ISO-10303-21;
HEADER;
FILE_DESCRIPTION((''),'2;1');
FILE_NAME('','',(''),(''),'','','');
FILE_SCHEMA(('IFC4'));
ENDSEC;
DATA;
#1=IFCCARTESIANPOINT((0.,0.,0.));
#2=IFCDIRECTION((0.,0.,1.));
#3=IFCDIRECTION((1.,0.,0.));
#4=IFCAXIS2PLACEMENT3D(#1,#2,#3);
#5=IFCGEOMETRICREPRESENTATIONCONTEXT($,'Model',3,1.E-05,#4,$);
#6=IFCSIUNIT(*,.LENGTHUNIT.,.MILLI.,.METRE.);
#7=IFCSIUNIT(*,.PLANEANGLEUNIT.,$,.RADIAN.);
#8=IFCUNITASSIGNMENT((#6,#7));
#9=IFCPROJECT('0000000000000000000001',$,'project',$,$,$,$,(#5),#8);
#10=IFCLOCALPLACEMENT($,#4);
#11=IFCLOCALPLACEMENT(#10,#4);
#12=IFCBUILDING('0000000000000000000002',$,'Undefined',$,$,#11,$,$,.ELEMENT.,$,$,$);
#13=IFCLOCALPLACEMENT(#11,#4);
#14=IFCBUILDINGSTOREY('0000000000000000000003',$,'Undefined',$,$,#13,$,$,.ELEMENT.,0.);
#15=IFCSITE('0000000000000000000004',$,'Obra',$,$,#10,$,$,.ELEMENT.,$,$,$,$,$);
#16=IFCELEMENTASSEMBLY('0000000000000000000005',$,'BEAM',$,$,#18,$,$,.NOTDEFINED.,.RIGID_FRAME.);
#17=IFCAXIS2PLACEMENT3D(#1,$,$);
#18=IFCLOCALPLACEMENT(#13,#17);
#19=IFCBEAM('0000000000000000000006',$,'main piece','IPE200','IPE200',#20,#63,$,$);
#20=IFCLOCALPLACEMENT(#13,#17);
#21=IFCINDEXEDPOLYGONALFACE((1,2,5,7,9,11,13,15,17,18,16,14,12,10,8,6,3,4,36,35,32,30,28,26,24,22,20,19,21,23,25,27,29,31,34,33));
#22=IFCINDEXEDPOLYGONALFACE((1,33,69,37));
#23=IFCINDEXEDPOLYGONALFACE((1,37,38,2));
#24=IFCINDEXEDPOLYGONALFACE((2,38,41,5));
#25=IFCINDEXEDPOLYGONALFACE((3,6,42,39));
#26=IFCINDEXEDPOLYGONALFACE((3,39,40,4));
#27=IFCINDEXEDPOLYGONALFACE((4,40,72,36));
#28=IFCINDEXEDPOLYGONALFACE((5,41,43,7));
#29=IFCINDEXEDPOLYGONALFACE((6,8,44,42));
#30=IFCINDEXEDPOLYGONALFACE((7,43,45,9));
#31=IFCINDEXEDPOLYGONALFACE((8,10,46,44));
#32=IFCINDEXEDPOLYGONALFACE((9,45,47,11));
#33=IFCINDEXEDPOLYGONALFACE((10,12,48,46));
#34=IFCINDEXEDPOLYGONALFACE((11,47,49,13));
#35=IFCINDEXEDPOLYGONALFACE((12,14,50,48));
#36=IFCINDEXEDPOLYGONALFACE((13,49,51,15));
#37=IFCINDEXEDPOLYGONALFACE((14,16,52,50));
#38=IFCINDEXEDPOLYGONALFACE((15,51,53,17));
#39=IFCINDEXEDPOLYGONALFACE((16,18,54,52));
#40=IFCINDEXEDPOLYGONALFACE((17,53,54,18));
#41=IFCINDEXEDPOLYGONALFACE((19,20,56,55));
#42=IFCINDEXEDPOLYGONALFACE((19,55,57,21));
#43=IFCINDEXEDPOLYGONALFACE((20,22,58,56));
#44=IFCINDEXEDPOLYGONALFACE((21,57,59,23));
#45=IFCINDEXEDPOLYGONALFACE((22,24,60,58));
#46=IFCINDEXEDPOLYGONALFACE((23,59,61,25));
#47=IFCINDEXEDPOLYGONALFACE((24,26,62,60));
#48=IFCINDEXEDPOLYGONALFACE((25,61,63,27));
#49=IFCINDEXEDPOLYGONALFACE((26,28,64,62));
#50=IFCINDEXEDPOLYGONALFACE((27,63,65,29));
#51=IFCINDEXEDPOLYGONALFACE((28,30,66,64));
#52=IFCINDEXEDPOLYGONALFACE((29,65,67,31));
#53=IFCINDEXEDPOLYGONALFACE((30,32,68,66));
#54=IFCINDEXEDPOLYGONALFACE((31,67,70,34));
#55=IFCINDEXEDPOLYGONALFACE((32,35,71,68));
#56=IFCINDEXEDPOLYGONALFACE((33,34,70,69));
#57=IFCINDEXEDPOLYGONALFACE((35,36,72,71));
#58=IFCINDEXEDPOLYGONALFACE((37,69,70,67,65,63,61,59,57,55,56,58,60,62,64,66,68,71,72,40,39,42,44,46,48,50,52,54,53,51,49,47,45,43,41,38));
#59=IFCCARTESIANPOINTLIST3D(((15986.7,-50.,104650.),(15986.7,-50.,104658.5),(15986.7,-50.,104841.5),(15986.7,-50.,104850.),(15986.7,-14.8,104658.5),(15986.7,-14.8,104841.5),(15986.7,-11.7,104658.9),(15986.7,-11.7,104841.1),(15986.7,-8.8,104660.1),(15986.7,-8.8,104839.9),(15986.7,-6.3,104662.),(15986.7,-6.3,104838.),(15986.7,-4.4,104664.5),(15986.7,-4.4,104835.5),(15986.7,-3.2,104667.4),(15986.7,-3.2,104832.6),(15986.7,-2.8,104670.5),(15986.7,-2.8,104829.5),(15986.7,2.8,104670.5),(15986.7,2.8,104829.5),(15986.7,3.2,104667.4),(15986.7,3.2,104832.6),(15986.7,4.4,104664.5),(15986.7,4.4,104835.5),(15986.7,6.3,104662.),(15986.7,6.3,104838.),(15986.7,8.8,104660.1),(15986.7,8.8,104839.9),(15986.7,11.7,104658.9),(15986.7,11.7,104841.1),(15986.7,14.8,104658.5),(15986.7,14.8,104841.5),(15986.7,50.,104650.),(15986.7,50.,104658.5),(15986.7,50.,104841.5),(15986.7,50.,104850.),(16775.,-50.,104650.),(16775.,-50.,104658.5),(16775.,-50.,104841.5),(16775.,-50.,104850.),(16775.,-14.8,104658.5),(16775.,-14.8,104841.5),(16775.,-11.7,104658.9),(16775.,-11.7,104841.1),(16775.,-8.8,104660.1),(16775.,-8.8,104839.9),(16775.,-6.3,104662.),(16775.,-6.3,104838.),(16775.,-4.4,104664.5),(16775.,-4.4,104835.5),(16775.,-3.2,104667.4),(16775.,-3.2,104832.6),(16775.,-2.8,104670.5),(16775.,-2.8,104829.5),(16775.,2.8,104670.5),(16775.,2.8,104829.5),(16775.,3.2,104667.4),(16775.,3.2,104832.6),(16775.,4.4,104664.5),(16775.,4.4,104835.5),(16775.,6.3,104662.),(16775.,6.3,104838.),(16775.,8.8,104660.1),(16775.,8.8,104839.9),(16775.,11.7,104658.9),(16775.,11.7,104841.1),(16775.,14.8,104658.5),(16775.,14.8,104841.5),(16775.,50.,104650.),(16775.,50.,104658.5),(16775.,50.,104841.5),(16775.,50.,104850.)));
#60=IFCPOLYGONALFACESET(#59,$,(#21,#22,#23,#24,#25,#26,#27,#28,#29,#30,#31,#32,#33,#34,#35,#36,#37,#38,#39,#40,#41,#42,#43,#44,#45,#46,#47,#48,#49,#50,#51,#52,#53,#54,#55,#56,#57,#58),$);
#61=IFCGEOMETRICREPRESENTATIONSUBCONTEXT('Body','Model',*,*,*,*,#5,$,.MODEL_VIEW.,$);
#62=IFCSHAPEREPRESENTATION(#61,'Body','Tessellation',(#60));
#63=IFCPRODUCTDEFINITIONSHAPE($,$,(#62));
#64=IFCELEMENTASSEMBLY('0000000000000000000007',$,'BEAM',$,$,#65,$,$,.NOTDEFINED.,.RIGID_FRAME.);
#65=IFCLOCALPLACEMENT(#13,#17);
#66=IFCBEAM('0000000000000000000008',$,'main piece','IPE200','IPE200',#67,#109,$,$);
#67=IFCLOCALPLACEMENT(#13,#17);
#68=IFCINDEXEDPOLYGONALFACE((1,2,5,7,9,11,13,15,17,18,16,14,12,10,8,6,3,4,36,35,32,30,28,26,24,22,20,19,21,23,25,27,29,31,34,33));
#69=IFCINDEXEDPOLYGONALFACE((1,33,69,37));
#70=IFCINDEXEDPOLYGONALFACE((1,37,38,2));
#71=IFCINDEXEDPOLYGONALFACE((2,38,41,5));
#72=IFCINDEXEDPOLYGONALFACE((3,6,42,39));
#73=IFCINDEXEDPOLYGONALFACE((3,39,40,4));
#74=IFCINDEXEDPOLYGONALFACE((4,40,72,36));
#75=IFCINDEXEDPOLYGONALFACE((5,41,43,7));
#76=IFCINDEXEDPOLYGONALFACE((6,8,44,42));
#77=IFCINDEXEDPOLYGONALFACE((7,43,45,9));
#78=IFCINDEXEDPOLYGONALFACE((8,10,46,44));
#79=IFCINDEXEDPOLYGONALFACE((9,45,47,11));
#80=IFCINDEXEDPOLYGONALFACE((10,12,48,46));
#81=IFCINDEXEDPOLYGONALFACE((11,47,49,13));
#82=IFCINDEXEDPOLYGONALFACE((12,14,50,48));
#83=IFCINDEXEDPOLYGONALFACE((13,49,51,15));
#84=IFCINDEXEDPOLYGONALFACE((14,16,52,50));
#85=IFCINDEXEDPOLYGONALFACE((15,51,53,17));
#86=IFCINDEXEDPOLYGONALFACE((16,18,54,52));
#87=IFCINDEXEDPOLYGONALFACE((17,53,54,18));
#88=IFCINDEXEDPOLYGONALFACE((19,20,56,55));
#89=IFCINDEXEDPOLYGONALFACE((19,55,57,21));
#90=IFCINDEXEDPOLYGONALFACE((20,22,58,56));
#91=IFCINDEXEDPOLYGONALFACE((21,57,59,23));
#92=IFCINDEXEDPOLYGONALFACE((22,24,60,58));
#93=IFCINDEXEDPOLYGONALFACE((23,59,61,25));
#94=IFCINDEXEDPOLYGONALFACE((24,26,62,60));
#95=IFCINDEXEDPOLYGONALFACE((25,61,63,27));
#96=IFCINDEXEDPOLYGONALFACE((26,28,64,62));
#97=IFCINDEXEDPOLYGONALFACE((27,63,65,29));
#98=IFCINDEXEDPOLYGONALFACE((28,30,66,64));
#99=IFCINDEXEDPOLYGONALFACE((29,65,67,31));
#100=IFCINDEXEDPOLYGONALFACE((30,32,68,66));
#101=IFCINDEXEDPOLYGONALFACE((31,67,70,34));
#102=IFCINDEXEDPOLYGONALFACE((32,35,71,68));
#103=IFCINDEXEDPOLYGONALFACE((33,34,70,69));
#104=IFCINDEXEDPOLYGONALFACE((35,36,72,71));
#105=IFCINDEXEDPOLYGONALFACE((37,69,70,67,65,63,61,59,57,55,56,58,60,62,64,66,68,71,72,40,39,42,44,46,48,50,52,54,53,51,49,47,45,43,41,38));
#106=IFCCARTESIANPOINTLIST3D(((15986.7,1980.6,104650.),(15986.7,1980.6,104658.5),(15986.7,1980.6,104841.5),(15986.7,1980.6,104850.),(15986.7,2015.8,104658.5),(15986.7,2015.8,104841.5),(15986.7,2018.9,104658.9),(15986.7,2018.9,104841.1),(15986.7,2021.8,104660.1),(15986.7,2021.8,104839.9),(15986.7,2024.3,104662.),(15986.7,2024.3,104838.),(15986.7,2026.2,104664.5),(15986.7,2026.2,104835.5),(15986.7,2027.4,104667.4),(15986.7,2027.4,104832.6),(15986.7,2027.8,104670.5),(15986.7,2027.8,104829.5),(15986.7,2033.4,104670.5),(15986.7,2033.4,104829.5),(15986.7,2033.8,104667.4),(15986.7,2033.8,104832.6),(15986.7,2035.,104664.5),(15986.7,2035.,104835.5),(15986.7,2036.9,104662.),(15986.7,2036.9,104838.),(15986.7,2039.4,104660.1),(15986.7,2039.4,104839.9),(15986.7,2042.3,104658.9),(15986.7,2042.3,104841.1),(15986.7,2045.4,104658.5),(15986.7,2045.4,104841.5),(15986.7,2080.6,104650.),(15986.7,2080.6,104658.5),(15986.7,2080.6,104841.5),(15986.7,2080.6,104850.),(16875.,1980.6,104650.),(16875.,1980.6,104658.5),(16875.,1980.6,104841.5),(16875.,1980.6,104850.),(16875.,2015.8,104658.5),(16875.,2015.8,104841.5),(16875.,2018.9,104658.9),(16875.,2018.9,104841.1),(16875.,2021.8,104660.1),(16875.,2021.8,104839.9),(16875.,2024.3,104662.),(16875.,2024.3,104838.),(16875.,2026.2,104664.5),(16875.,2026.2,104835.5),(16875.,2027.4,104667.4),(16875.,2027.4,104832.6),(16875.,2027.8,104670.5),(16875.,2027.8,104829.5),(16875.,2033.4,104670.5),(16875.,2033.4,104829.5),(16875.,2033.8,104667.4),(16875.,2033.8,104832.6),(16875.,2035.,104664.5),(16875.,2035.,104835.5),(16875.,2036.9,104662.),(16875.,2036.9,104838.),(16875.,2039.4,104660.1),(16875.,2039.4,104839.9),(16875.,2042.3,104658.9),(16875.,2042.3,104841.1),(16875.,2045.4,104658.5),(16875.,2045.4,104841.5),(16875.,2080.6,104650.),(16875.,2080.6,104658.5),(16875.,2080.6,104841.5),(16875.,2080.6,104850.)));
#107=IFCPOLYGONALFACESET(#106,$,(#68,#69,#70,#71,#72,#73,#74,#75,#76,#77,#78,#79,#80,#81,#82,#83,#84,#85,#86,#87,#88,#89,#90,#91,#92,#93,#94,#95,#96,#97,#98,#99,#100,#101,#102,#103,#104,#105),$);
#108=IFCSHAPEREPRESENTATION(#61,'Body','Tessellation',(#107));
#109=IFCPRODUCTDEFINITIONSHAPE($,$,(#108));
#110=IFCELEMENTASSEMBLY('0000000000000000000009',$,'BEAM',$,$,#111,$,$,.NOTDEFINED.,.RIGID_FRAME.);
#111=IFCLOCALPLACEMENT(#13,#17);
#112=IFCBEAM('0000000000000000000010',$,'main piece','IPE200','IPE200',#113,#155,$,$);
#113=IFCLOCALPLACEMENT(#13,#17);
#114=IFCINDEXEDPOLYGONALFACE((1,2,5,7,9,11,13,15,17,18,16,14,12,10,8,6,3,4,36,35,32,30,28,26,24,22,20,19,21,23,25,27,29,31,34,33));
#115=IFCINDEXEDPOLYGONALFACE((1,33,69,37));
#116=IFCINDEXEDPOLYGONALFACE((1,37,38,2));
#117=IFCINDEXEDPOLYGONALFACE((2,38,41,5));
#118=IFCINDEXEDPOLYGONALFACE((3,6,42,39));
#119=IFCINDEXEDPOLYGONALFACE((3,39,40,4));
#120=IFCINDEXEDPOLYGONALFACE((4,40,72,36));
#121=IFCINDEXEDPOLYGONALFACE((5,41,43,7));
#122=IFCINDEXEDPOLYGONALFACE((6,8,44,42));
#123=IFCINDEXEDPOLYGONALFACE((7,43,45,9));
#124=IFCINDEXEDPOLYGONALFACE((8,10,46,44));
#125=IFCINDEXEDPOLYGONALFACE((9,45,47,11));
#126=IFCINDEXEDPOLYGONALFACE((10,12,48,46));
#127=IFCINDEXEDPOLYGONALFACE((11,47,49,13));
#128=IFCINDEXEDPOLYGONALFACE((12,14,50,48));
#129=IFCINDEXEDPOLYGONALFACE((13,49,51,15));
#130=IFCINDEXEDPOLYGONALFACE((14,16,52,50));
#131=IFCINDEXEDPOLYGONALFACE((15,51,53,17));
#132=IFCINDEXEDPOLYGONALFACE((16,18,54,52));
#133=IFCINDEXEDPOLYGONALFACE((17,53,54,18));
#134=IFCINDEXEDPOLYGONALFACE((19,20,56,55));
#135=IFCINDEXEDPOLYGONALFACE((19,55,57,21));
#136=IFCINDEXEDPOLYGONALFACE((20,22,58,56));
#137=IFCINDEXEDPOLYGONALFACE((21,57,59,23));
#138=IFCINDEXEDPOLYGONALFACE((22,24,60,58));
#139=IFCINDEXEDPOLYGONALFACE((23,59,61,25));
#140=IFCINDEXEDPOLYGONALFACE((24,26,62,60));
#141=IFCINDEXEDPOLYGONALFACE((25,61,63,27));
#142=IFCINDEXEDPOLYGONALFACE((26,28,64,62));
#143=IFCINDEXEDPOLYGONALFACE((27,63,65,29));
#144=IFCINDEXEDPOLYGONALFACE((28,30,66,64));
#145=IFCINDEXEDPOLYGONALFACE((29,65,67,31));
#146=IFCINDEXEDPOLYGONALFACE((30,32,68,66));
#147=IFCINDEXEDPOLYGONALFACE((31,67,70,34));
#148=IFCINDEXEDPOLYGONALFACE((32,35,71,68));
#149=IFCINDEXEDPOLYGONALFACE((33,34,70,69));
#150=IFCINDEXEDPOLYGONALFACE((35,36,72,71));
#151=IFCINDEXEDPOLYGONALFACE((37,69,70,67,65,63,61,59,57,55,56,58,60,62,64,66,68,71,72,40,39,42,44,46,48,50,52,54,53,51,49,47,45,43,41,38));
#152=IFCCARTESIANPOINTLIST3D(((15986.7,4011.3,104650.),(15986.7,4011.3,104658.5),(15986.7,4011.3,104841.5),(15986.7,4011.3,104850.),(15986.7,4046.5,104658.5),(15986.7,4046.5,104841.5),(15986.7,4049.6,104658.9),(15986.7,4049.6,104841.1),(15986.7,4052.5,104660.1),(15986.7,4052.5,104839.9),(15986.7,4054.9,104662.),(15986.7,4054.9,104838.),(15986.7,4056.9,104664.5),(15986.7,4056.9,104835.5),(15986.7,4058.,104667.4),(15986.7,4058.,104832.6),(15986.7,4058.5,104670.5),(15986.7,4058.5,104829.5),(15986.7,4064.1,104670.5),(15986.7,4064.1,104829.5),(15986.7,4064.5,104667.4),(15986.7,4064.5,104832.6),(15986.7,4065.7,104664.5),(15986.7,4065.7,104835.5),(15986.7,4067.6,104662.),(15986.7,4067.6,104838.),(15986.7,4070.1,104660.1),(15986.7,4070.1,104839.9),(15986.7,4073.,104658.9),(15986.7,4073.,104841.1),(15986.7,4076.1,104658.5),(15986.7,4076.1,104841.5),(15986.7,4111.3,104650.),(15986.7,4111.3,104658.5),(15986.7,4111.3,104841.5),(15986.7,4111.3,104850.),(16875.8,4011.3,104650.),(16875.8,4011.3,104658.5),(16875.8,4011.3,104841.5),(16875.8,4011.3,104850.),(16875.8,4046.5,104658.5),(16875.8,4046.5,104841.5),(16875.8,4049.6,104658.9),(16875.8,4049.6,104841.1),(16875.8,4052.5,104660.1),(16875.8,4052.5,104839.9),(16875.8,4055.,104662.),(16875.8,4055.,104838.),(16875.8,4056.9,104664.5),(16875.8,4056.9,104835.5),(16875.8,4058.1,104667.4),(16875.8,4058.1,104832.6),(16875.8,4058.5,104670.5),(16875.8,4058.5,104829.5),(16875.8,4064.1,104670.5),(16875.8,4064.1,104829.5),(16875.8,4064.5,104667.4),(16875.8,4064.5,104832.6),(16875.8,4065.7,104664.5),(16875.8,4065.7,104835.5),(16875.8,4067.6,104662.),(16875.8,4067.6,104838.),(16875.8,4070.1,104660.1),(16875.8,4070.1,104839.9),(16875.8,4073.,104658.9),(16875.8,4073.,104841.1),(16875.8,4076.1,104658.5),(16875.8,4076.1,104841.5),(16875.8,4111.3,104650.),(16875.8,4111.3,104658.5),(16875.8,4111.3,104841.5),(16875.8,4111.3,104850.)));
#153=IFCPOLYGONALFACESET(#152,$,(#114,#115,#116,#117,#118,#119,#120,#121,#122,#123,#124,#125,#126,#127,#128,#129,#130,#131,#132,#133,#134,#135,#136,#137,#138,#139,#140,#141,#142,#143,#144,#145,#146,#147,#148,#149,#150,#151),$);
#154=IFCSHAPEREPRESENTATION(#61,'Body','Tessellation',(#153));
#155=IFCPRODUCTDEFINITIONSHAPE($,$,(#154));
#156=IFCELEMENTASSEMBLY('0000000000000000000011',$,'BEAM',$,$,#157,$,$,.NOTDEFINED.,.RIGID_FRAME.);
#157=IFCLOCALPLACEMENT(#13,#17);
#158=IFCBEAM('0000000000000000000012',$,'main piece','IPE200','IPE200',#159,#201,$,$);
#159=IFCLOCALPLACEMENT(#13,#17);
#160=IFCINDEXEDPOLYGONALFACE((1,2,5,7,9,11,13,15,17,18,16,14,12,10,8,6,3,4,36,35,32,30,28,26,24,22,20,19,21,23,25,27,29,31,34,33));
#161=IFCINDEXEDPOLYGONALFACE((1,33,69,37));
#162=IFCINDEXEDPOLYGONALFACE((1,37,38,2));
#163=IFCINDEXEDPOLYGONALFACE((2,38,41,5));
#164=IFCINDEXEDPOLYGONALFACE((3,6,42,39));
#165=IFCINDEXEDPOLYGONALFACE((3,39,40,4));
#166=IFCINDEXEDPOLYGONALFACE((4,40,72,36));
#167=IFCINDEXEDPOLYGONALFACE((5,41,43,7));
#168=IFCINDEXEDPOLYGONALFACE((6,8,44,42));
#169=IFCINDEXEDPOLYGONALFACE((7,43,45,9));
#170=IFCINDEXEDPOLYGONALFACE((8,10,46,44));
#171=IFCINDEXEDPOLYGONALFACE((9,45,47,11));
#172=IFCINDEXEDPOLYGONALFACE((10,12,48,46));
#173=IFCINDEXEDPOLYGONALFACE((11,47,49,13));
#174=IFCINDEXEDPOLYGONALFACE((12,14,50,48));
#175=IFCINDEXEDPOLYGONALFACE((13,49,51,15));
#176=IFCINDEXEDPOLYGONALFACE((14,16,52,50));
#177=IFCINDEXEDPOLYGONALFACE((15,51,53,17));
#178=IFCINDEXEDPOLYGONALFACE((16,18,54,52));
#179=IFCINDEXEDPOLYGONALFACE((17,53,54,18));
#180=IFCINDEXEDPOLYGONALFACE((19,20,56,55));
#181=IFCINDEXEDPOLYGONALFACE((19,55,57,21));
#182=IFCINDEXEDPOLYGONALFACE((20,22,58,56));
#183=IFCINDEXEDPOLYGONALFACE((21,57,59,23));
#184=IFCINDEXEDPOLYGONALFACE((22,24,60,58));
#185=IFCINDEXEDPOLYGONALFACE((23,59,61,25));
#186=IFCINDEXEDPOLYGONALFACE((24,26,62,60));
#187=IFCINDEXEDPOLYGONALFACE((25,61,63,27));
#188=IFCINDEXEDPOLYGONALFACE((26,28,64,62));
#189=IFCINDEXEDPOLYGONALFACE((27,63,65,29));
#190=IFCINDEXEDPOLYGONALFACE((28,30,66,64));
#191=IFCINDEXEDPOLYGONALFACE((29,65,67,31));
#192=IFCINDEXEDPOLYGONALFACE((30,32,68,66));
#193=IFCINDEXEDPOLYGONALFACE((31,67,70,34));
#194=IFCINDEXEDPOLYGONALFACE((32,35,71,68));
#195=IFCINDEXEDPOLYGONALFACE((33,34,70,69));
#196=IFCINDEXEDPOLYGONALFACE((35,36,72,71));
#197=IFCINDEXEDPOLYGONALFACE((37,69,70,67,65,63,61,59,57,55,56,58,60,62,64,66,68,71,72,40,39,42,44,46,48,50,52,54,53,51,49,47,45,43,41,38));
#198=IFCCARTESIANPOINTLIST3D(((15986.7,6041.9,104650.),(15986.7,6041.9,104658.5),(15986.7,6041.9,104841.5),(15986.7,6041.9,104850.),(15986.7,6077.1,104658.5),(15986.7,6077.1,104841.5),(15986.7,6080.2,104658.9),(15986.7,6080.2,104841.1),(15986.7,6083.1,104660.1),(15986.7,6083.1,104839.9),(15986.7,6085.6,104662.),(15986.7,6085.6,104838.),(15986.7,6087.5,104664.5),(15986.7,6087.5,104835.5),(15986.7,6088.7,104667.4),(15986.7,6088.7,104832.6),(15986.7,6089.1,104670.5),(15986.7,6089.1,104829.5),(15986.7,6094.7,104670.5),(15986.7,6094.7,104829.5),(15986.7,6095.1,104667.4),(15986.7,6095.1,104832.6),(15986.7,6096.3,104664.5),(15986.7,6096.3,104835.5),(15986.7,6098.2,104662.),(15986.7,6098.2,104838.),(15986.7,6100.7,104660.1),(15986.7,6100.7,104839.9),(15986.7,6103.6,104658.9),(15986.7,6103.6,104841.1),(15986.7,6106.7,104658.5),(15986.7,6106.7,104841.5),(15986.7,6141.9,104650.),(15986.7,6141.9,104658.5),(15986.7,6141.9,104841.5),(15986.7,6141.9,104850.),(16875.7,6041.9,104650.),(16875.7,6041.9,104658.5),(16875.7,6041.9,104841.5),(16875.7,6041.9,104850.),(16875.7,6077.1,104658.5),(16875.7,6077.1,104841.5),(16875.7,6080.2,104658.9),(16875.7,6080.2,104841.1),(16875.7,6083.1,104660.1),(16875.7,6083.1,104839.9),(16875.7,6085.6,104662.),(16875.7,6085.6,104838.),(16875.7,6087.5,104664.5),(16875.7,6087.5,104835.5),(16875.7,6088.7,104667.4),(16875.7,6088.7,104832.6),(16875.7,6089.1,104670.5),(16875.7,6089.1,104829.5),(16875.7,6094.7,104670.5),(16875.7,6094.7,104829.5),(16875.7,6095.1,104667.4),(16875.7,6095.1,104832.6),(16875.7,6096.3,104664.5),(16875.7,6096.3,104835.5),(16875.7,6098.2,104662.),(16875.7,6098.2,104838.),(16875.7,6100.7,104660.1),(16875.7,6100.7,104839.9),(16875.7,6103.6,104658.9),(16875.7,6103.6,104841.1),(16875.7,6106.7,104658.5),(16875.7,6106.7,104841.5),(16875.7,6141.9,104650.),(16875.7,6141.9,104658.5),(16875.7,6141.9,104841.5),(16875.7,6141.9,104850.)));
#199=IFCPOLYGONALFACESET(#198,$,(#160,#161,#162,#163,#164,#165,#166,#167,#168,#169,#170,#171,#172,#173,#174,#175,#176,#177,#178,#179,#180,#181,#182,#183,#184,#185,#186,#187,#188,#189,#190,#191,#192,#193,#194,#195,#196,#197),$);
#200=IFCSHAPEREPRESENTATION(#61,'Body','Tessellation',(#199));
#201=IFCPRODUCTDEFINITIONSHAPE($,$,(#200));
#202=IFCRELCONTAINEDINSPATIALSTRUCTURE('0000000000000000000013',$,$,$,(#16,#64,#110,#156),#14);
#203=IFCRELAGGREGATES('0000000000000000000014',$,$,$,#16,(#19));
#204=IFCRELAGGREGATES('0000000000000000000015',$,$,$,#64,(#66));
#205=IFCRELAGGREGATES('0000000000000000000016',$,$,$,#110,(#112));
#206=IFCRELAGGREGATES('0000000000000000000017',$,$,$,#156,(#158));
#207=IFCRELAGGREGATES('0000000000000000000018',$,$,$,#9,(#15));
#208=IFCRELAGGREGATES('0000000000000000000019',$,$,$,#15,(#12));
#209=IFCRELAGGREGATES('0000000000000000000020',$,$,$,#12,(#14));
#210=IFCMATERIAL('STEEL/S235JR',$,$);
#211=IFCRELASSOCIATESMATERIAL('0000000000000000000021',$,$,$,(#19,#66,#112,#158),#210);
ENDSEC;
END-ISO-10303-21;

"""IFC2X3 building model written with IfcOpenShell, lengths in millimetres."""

from ifc_helpers import new_model, si_unit, frame, origin_with_axes, origin_2d_with_axis, place, context, subcontext, project, spatial, i_section, extrude, material, element, aggregate, save


model = new_model("IFC2X3")

# Units and contexts
model_context = context("Model", 3, precision=1e-05, world=origin_with_axes())
body_context = subcontext(model_context, "Body", "Model", "MODEL_VIEW")
ifc_project = project(units=[si_unit("LENGTHUNIT", "METRE", prefix="MILLI"), si_unit("PLANEANGLEUNIT", "RADIAN")], contexts=[model_context])

# Site, building, storey
site_placement = place(None, origin_with_axes())
site = spatial("IfcSite", under=ifc_project, at=site_placement, Name="Obra", CompositionType="ELEMENT")
building_placement = place(site_placement, origin_with_axes())
building = spatial("IfcBuilding", under=site, at=building_placement, Name="Undefined", CompositionType="ELEMENT")
storey_placement = place(building_placement, origin_with_axes())
storey = spatial("IfcBuildingStorey", under=building, at=storey_placement, Name="Undefined", CompositionType="ELEMENT", Elevation=0.0)

# Shared definitions
ifc_material_1 = material(Name="STEEL/S235JR")

# Element assemblies, beams
assembly_1_placement = place(storey_placement, origin_with_axes())
assembly_1 = element("IfcElementAssembly", 1, at=assembly_1_placement, inside=storey, Name="BEAM", AssemblyPlace="NOTDEFINED", PredefinedType="RIGID_FRAME")
beam_1_placement = place(assembly_1_placement, frame((16775.0, 0.0, 104750.0), z_axis=(0.0, 0.0, 1.0), x_axis=(-1.0, 0.0, 0.0)))
beam_1 = element("IfcBeam", 2, at=beam_1_placement, material=ifc_material_1, Name="main piece", Description="IPE200", ObjectType="IPE200", context=body_context, shape_type="SweptSolid", body=[
    extrude(i_section(OverallWidth=100.0, OverallDepth=200.0, WebThickness=5.6, FlangeThickness=8.5, FilletRadius=12.0, at=origin_2d_with_axis()), frame((788.3, 0.0, 0.0), z_axis=(-1.0, 0.0, 0.0), x_axis=(0.0, -1.0, 0.0)), (0.0, 0.0, 1.0), 788.3),
])
aggregate(assembly_1, [beam_1])
assembly_2_placement = place(storey_placement, origin_with_axes())
assembly_2 = element("IfcElementAssembly", 3, at=assembly_2_placement, inside=storey, Name="BEAM", AssemblyPlace="NOTDEFINED", PredefinedType="RIGID_FRAME")
beam_2_placement = place(assembly_2_placement, frame((16875.0, 2030.6, 104750.0), z_axis=(0.0, 0.0, 1.0), x_axis=(-1.0, 0.0, 0.0)))
beam_2 = element("IfcBeam", 4, at=beam_2_placement, material=ifc_material_1, Name="main piece", Description="IPE200", ObjectType="IPE200", context=body_context, shape_type="SweptSolid", body=[
    extrude(i_section(OverallWidth=100.0, OverallDepth=200.0, WebThickness=5.6, FlangeThickness=8.5, FilletRadius=12.0, at=origin_2d_with_axis()), frame((888.3, 0.0, 0.0), z_axis=(-1.0, 0.0, 0.0), x_axis=(0.0, -1.0, 0.0)), (0.0, 0.0, 1.0), 888.3),
])
aggregate(assembly_2, [beam_2])
assembly_3_placement = place(storey_placement, origin_with_axes())
assembly_3 = element("IfcElementAssembly", 5, at=assembly_3_placement, inside=storey, Name="BEAM", AssemblyPlace="NOTDEFINED", PredefinedType="RIGID_FRAME")
beam_3_placement = place(assembly_3_placement, frame((16875.8, 4061.3, 104750.0), z_axis=(0.0, 0.0, 1.0), x_axis=(-1.0, -0.000044, 0.0)))
beam_3 = element("IfcBeam", 6, at=beam_3_placement, material=ifc_material_1, Name="main piece", Description="IPE200", ObjectType="IPE200", context=body_context, shape_type="SweptSolid", body=[
    extrude(i_section(OverallWidth=100.0, OverallDepth=200.0, WebThickness=5.6, FlangeThickness=8.5, FilletRadius=12.0, at=origin_2d_with_axis()), frame((889.1, 0.0, 0.0), z_axis=(-1.0, 0.0, 0.0), x_axis=(0.0, -1.0, 0.0)), (0.0, 0.0, 1.0), 889.1),
])
aggregate(assembly_3, [beam_3])
assembly_4_placement = place(storey_placement, origin_with_axes())
assembly_4 = element("IfcElementAssembly", 7, at=assembly_4_placement, inside=storey, Name="BEAM", AssemblyPlace="NOTDEFINED", PredefinedType="RIGID_FRAME")
beam_4_placement = place(assembly_4_placement, frame((16875.7, 6091.9, 104750.0), z_axis=(0.0, 0.0, 1.0), x_axis=(-1.0, 0.0, 0.0)))
beam_4 = element("IfcBeam", 8, at=beam_4_placement, material=ifc_material_1, Name="main piece", Description="IPE200", ObjectType="IPE200", context=body_context, shape_type="SweptSolid", body=[
    extrude(i_section(OverallWidth=100.0, OverallDepth=200.0, WebThickness=5.6, FlangeThickness=8.5, FilletRadius=12.0, at=origin_2d_with_axis()), frame((889.0, 0.0, 0.0), z_axis=(-1.0, 0.0, 0.0), x_axis=(0.0, -1.0, 0.0)), (0.0, 0.0, 1.0), 889.0),
])
aggregate(assembly_4, [beam_4])

save(model, "model.ifc")
